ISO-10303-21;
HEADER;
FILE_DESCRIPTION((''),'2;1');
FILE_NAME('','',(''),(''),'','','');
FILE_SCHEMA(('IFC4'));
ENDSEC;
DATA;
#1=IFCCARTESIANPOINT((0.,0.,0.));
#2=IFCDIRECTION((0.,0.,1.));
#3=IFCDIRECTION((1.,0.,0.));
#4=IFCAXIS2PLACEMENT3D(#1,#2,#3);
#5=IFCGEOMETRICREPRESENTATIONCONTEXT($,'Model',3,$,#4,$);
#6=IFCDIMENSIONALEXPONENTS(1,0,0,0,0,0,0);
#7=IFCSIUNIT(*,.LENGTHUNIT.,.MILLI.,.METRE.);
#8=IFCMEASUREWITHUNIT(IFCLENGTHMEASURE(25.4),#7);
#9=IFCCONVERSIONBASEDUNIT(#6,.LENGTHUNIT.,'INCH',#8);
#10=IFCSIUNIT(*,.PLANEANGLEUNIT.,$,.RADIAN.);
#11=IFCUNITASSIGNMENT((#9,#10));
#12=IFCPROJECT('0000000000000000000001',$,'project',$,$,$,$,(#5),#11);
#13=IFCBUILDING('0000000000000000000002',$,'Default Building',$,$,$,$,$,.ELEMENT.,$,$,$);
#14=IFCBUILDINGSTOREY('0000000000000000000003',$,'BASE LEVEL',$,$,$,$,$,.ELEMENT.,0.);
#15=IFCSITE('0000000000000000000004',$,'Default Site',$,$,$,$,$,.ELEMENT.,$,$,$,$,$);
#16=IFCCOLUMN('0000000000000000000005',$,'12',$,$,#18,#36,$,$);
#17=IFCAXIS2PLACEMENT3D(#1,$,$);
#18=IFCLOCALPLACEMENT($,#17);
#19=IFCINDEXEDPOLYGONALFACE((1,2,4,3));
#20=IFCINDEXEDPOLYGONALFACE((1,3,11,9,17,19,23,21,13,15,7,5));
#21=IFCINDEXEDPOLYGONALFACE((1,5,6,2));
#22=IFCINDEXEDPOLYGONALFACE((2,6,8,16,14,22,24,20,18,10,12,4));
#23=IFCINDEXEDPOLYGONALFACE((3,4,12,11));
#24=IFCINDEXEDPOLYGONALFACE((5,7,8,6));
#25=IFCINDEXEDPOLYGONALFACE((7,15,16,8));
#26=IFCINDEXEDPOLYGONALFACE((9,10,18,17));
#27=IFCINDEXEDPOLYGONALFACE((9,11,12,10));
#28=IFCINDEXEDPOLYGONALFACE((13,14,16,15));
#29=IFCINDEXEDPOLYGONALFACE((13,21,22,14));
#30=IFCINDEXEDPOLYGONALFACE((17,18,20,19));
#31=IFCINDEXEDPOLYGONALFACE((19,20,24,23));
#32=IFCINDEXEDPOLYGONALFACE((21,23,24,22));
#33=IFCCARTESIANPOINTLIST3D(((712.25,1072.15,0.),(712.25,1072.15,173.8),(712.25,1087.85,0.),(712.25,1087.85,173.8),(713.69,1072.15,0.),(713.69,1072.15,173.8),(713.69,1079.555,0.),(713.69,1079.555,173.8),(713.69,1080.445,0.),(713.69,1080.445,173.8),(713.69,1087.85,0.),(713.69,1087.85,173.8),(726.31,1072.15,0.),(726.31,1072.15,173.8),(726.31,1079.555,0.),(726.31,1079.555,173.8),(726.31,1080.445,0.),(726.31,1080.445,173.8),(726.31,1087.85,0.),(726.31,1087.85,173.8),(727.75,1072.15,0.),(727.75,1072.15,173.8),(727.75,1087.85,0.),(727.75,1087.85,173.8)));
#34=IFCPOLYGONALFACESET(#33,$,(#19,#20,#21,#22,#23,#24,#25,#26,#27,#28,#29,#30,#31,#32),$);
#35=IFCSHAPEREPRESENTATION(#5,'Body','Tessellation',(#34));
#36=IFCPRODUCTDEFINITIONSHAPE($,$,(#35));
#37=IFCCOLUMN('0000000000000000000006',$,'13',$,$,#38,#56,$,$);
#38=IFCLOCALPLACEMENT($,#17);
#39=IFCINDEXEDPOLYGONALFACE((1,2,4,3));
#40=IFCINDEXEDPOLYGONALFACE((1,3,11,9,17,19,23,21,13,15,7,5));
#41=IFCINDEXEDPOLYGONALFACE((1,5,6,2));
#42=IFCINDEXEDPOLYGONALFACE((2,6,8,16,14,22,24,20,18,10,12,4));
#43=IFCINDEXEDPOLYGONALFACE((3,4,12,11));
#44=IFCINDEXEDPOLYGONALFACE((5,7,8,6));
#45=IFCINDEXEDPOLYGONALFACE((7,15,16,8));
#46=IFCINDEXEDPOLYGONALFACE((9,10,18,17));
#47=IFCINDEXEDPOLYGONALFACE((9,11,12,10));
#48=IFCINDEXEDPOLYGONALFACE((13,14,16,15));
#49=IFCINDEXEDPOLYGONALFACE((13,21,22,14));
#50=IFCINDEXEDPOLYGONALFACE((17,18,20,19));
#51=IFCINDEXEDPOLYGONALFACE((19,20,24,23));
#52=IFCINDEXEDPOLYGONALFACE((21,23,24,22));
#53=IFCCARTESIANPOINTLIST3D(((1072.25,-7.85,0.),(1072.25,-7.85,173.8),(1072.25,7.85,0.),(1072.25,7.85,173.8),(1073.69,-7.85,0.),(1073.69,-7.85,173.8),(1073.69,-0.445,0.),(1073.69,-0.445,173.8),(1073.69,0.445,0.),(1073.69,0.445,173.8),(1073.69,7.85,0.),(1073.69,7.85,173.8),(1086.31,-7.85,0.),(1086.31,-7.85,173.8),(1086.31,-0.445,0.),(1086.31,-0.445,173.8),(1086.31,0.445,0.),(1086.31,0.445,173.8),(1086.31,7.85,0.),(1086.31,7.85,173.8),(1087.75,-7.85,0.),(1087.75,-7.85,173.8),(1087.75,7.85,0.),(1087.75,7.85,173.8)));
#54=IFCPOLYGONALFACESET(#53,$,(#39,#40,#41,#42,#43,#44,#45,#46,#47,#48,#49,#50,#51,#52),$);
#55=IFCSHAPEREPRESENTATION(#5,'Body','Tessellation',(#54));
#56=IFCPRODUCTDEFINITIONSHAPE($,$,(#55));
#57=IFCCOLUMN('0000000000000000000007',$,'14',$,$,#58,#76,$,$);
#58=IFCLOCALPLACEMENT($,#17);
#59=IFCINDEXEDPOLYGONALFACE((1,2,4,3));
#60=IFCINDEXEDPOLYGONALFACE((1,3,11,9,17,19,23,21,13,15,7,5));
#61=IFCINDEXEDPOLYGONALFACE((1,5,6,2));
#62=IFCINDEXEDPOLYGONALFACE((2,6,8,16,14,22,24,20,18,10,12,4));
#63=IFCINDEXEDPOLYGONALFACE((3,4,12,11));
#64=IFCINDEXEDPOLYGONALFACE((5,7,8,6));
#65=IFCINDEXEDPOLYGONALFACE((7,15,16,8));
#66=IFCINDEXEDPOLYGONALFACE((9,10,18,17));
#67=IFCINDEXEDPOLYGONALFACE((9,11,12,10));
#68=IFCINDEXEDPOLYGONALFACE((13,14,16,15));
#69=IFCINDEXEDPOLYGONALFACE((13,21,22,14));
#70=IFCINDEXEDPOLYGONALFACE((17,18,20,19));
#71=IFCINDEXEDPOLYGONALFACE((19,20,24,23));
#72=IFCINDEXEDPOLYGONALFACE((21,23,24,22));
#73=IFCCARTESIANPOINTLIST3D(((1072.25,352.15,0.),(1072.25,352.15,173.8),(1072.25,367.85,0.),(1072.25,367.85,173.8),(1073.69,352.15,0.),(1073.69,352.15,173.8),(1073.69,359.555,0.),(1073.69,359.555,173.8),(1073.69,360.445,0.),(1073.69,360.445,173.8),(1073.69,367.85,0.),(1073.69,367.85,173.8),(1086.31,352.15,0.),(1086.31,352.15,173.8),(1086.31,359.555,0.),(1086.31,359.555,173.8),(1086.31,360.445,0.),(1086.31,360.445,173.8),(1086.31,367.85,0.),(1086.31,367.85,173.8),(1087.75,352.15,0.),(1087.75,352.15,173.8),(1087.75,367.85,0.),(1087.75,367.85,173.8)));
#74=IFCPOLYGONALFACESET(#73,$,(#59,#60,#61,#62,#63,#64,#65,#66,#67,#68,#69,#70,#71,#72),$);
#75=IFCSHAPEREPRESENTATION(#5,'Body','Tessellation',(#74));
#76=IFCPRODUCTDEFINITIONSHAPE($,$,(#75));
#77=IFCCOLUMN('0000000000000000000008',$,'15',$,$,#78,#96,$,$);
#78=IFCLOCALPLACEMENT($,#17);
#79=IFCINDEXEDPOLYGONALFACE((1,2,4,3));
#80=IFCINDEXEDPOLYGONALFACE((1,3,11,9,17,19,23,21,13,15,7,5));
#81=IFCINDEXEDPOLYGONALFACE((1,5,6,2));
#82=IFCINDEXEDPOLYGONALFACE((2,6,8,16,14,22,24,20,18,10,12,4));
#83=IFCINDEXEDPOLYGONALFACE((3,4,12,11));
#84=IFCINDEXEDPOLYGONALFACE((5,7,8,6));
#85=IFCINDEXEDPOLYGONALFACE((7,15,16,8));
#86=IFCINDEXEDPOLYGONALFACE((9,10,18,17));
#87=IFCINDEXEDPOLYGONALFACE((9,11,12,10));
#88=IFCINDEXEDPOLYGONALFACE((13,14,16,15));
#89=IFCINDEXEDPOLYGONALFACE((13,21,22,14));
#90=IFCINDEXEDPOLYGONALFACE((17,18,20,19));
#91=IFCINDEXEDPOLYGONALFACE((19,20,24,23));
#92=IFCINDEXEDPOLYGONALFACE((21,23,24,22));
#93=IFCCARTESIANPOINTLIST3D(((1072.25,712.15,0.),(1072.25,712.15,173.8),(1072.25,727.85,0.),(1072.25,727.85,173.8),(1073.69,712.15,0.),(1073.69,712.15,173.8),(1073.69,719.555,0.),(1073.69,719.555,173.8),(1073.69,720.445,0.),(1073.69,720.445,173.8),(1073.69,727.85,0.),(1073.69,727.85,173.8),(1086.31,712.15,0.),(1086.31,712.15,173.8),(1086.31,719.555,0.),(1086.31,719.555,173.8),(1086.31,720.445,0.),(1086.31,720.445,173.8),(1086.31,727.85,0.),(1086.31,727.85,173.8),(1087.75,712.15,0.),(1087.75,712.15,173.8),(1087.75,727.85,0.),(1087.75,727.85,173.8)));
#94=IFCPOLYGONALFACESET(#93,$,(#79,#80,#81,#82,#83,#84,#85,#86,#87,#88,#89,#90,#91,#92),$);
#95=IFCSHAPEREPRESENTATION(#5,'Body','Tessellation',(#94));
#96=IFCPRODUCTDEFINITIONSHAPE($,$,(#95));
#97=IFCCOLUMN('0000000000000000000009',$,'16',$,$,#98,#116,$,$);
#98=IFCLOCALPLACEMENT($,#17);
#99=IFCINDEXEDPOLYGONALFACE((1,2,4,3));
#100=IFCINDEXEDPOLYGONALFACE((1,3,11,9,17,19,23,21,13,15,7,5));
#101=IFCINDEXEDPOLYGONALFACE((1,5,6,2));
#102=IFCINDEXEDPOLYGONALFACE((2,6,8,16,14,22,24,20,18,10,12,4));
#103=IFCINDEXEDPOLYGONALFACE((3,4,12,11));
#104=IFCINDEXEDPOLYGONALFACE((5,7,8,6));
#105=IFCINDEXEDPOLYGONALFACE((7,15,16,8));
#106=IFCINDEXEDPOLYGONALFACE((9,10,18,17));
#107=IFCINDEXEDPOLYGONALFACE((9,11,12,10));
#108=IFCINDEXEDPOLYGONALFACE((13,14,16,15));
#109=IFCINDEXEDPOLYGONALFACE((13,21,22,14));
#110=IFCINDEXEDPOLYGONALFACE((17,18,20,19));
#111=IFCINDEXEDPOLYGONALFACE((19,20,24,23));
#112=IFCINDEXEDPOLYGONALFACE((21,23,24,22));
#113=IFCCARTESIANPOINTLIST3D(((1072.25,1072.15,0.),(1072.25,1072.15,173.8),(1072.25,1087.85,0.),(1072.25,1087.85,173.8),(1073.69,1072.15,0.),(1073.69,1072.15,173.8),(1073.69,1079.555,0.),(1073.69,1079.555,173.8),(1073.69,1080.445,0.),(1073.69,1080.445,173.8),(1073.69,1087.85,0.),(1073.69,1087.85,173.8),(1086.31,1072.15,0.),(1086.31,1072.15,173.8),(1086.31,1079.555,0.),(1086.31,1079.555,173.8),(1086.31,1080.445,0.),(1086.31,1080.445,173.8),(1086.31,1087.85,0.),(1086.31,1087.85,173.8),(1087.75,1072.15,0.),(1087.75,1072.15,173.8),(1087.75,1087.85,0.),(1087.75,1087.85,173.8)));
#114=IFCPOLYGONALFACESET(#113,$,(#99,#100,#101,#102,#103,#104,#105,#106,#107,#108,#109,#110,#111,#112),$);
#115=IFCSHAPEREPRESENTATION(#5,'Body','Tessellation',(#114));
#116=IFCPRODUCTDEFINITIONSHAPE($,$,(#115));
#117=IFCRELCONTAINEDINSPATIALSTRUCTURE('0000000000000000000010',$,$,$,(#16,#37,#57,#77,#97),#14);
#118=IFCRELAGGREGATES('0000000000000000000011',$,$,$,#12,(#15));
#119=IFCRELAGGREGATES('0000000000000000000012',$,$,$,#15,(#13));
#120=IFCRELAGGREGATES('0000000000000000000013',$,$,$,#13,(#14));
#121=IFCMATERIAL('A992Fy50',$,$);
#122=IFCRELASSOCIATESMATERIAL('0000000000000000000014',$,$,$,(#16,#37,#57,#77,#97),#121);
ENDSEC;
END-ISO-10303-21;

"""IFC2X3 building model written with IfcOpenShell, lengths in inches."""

from ifc_helpers import new_model, entity, si_unit, converted_unit, frame, origin_with_axes, origin_2d_with_axis, place, context, project, spatial, i_section, extrude, material, element, save


model = new_model("IFC2X3")

# Units and contexts
model_context = context("Model", 3, world=origin_with_axes())
ifc_project = project(units=[converted_unit("LENGTHUNIT", "INCH", entity("IfcLengthMeasure", 25.4), si_unit("LENGTHUNIT", "METRE", prefix="MILLI"), dimensions=[1, 0, 0, 0, 0, 0, 0]), si_unit("PLANEANGLEUNIT", "RADIAN")], contexts=[model_context])

# Site, building, storey
site = spatial("IfcSite", under=ifc_project, Name="Default Site", CompositionType="ELEMENT")
building = spatial("IfcBuilding", under=site, Name="Default Building", CompositionType="ELEMENT")
storey = spatial("IfcBuildingStorey", under=building, Name="BASE LEVEL", CompositionType="ELEMENT", Elevation=0.0)

# Columns
ifc_material = material(Name="A992Fy50")
for number, where, z_axis, x_axis, name in (
    (1, (720.0, 1080.0, 0.0), (0.0, 0.0, 1.0), (0.0, -1.0, 0.0), "12"),
    (2, (1080.0, 0.0, 0.0), (0.0, 0.0, 1.0), (0.0, -1.0, 0.0), "13"),
    (3, (1080.0, 360.0, 0.0), (0.0, 0.0, 1.0), (0.0, -1.0, 0.0), "14"),
    (4, (1080.0, 720.0, 0.0), (0.0, 0.0, 1.0), (0.0, -1.0, 0.0), "15"),
    (5, (1080.0, 1080.0, 0.0), (0.0, 0.0, 1.0), (0.0, -1.0, 0.0), "16"),
):
    element("IfcColumn", number, at=place(None, frame(where, z_axis=z_axis, x_axis=x_axis)), inside=storey, material=ifc_material, Name=name, context=model_context, shape_type="SweptSolid", body=[
        extrude(i_section(OverallWidth=15.7, OverallDepth=15.5, WebThickness=0.89, FlangeThickness=1.44, at=origin_2d_with_axis()), origin_with_axes(), (0.0, 0.0, 1.0), 173.8),
    ])

save(model, "model.ifc")
